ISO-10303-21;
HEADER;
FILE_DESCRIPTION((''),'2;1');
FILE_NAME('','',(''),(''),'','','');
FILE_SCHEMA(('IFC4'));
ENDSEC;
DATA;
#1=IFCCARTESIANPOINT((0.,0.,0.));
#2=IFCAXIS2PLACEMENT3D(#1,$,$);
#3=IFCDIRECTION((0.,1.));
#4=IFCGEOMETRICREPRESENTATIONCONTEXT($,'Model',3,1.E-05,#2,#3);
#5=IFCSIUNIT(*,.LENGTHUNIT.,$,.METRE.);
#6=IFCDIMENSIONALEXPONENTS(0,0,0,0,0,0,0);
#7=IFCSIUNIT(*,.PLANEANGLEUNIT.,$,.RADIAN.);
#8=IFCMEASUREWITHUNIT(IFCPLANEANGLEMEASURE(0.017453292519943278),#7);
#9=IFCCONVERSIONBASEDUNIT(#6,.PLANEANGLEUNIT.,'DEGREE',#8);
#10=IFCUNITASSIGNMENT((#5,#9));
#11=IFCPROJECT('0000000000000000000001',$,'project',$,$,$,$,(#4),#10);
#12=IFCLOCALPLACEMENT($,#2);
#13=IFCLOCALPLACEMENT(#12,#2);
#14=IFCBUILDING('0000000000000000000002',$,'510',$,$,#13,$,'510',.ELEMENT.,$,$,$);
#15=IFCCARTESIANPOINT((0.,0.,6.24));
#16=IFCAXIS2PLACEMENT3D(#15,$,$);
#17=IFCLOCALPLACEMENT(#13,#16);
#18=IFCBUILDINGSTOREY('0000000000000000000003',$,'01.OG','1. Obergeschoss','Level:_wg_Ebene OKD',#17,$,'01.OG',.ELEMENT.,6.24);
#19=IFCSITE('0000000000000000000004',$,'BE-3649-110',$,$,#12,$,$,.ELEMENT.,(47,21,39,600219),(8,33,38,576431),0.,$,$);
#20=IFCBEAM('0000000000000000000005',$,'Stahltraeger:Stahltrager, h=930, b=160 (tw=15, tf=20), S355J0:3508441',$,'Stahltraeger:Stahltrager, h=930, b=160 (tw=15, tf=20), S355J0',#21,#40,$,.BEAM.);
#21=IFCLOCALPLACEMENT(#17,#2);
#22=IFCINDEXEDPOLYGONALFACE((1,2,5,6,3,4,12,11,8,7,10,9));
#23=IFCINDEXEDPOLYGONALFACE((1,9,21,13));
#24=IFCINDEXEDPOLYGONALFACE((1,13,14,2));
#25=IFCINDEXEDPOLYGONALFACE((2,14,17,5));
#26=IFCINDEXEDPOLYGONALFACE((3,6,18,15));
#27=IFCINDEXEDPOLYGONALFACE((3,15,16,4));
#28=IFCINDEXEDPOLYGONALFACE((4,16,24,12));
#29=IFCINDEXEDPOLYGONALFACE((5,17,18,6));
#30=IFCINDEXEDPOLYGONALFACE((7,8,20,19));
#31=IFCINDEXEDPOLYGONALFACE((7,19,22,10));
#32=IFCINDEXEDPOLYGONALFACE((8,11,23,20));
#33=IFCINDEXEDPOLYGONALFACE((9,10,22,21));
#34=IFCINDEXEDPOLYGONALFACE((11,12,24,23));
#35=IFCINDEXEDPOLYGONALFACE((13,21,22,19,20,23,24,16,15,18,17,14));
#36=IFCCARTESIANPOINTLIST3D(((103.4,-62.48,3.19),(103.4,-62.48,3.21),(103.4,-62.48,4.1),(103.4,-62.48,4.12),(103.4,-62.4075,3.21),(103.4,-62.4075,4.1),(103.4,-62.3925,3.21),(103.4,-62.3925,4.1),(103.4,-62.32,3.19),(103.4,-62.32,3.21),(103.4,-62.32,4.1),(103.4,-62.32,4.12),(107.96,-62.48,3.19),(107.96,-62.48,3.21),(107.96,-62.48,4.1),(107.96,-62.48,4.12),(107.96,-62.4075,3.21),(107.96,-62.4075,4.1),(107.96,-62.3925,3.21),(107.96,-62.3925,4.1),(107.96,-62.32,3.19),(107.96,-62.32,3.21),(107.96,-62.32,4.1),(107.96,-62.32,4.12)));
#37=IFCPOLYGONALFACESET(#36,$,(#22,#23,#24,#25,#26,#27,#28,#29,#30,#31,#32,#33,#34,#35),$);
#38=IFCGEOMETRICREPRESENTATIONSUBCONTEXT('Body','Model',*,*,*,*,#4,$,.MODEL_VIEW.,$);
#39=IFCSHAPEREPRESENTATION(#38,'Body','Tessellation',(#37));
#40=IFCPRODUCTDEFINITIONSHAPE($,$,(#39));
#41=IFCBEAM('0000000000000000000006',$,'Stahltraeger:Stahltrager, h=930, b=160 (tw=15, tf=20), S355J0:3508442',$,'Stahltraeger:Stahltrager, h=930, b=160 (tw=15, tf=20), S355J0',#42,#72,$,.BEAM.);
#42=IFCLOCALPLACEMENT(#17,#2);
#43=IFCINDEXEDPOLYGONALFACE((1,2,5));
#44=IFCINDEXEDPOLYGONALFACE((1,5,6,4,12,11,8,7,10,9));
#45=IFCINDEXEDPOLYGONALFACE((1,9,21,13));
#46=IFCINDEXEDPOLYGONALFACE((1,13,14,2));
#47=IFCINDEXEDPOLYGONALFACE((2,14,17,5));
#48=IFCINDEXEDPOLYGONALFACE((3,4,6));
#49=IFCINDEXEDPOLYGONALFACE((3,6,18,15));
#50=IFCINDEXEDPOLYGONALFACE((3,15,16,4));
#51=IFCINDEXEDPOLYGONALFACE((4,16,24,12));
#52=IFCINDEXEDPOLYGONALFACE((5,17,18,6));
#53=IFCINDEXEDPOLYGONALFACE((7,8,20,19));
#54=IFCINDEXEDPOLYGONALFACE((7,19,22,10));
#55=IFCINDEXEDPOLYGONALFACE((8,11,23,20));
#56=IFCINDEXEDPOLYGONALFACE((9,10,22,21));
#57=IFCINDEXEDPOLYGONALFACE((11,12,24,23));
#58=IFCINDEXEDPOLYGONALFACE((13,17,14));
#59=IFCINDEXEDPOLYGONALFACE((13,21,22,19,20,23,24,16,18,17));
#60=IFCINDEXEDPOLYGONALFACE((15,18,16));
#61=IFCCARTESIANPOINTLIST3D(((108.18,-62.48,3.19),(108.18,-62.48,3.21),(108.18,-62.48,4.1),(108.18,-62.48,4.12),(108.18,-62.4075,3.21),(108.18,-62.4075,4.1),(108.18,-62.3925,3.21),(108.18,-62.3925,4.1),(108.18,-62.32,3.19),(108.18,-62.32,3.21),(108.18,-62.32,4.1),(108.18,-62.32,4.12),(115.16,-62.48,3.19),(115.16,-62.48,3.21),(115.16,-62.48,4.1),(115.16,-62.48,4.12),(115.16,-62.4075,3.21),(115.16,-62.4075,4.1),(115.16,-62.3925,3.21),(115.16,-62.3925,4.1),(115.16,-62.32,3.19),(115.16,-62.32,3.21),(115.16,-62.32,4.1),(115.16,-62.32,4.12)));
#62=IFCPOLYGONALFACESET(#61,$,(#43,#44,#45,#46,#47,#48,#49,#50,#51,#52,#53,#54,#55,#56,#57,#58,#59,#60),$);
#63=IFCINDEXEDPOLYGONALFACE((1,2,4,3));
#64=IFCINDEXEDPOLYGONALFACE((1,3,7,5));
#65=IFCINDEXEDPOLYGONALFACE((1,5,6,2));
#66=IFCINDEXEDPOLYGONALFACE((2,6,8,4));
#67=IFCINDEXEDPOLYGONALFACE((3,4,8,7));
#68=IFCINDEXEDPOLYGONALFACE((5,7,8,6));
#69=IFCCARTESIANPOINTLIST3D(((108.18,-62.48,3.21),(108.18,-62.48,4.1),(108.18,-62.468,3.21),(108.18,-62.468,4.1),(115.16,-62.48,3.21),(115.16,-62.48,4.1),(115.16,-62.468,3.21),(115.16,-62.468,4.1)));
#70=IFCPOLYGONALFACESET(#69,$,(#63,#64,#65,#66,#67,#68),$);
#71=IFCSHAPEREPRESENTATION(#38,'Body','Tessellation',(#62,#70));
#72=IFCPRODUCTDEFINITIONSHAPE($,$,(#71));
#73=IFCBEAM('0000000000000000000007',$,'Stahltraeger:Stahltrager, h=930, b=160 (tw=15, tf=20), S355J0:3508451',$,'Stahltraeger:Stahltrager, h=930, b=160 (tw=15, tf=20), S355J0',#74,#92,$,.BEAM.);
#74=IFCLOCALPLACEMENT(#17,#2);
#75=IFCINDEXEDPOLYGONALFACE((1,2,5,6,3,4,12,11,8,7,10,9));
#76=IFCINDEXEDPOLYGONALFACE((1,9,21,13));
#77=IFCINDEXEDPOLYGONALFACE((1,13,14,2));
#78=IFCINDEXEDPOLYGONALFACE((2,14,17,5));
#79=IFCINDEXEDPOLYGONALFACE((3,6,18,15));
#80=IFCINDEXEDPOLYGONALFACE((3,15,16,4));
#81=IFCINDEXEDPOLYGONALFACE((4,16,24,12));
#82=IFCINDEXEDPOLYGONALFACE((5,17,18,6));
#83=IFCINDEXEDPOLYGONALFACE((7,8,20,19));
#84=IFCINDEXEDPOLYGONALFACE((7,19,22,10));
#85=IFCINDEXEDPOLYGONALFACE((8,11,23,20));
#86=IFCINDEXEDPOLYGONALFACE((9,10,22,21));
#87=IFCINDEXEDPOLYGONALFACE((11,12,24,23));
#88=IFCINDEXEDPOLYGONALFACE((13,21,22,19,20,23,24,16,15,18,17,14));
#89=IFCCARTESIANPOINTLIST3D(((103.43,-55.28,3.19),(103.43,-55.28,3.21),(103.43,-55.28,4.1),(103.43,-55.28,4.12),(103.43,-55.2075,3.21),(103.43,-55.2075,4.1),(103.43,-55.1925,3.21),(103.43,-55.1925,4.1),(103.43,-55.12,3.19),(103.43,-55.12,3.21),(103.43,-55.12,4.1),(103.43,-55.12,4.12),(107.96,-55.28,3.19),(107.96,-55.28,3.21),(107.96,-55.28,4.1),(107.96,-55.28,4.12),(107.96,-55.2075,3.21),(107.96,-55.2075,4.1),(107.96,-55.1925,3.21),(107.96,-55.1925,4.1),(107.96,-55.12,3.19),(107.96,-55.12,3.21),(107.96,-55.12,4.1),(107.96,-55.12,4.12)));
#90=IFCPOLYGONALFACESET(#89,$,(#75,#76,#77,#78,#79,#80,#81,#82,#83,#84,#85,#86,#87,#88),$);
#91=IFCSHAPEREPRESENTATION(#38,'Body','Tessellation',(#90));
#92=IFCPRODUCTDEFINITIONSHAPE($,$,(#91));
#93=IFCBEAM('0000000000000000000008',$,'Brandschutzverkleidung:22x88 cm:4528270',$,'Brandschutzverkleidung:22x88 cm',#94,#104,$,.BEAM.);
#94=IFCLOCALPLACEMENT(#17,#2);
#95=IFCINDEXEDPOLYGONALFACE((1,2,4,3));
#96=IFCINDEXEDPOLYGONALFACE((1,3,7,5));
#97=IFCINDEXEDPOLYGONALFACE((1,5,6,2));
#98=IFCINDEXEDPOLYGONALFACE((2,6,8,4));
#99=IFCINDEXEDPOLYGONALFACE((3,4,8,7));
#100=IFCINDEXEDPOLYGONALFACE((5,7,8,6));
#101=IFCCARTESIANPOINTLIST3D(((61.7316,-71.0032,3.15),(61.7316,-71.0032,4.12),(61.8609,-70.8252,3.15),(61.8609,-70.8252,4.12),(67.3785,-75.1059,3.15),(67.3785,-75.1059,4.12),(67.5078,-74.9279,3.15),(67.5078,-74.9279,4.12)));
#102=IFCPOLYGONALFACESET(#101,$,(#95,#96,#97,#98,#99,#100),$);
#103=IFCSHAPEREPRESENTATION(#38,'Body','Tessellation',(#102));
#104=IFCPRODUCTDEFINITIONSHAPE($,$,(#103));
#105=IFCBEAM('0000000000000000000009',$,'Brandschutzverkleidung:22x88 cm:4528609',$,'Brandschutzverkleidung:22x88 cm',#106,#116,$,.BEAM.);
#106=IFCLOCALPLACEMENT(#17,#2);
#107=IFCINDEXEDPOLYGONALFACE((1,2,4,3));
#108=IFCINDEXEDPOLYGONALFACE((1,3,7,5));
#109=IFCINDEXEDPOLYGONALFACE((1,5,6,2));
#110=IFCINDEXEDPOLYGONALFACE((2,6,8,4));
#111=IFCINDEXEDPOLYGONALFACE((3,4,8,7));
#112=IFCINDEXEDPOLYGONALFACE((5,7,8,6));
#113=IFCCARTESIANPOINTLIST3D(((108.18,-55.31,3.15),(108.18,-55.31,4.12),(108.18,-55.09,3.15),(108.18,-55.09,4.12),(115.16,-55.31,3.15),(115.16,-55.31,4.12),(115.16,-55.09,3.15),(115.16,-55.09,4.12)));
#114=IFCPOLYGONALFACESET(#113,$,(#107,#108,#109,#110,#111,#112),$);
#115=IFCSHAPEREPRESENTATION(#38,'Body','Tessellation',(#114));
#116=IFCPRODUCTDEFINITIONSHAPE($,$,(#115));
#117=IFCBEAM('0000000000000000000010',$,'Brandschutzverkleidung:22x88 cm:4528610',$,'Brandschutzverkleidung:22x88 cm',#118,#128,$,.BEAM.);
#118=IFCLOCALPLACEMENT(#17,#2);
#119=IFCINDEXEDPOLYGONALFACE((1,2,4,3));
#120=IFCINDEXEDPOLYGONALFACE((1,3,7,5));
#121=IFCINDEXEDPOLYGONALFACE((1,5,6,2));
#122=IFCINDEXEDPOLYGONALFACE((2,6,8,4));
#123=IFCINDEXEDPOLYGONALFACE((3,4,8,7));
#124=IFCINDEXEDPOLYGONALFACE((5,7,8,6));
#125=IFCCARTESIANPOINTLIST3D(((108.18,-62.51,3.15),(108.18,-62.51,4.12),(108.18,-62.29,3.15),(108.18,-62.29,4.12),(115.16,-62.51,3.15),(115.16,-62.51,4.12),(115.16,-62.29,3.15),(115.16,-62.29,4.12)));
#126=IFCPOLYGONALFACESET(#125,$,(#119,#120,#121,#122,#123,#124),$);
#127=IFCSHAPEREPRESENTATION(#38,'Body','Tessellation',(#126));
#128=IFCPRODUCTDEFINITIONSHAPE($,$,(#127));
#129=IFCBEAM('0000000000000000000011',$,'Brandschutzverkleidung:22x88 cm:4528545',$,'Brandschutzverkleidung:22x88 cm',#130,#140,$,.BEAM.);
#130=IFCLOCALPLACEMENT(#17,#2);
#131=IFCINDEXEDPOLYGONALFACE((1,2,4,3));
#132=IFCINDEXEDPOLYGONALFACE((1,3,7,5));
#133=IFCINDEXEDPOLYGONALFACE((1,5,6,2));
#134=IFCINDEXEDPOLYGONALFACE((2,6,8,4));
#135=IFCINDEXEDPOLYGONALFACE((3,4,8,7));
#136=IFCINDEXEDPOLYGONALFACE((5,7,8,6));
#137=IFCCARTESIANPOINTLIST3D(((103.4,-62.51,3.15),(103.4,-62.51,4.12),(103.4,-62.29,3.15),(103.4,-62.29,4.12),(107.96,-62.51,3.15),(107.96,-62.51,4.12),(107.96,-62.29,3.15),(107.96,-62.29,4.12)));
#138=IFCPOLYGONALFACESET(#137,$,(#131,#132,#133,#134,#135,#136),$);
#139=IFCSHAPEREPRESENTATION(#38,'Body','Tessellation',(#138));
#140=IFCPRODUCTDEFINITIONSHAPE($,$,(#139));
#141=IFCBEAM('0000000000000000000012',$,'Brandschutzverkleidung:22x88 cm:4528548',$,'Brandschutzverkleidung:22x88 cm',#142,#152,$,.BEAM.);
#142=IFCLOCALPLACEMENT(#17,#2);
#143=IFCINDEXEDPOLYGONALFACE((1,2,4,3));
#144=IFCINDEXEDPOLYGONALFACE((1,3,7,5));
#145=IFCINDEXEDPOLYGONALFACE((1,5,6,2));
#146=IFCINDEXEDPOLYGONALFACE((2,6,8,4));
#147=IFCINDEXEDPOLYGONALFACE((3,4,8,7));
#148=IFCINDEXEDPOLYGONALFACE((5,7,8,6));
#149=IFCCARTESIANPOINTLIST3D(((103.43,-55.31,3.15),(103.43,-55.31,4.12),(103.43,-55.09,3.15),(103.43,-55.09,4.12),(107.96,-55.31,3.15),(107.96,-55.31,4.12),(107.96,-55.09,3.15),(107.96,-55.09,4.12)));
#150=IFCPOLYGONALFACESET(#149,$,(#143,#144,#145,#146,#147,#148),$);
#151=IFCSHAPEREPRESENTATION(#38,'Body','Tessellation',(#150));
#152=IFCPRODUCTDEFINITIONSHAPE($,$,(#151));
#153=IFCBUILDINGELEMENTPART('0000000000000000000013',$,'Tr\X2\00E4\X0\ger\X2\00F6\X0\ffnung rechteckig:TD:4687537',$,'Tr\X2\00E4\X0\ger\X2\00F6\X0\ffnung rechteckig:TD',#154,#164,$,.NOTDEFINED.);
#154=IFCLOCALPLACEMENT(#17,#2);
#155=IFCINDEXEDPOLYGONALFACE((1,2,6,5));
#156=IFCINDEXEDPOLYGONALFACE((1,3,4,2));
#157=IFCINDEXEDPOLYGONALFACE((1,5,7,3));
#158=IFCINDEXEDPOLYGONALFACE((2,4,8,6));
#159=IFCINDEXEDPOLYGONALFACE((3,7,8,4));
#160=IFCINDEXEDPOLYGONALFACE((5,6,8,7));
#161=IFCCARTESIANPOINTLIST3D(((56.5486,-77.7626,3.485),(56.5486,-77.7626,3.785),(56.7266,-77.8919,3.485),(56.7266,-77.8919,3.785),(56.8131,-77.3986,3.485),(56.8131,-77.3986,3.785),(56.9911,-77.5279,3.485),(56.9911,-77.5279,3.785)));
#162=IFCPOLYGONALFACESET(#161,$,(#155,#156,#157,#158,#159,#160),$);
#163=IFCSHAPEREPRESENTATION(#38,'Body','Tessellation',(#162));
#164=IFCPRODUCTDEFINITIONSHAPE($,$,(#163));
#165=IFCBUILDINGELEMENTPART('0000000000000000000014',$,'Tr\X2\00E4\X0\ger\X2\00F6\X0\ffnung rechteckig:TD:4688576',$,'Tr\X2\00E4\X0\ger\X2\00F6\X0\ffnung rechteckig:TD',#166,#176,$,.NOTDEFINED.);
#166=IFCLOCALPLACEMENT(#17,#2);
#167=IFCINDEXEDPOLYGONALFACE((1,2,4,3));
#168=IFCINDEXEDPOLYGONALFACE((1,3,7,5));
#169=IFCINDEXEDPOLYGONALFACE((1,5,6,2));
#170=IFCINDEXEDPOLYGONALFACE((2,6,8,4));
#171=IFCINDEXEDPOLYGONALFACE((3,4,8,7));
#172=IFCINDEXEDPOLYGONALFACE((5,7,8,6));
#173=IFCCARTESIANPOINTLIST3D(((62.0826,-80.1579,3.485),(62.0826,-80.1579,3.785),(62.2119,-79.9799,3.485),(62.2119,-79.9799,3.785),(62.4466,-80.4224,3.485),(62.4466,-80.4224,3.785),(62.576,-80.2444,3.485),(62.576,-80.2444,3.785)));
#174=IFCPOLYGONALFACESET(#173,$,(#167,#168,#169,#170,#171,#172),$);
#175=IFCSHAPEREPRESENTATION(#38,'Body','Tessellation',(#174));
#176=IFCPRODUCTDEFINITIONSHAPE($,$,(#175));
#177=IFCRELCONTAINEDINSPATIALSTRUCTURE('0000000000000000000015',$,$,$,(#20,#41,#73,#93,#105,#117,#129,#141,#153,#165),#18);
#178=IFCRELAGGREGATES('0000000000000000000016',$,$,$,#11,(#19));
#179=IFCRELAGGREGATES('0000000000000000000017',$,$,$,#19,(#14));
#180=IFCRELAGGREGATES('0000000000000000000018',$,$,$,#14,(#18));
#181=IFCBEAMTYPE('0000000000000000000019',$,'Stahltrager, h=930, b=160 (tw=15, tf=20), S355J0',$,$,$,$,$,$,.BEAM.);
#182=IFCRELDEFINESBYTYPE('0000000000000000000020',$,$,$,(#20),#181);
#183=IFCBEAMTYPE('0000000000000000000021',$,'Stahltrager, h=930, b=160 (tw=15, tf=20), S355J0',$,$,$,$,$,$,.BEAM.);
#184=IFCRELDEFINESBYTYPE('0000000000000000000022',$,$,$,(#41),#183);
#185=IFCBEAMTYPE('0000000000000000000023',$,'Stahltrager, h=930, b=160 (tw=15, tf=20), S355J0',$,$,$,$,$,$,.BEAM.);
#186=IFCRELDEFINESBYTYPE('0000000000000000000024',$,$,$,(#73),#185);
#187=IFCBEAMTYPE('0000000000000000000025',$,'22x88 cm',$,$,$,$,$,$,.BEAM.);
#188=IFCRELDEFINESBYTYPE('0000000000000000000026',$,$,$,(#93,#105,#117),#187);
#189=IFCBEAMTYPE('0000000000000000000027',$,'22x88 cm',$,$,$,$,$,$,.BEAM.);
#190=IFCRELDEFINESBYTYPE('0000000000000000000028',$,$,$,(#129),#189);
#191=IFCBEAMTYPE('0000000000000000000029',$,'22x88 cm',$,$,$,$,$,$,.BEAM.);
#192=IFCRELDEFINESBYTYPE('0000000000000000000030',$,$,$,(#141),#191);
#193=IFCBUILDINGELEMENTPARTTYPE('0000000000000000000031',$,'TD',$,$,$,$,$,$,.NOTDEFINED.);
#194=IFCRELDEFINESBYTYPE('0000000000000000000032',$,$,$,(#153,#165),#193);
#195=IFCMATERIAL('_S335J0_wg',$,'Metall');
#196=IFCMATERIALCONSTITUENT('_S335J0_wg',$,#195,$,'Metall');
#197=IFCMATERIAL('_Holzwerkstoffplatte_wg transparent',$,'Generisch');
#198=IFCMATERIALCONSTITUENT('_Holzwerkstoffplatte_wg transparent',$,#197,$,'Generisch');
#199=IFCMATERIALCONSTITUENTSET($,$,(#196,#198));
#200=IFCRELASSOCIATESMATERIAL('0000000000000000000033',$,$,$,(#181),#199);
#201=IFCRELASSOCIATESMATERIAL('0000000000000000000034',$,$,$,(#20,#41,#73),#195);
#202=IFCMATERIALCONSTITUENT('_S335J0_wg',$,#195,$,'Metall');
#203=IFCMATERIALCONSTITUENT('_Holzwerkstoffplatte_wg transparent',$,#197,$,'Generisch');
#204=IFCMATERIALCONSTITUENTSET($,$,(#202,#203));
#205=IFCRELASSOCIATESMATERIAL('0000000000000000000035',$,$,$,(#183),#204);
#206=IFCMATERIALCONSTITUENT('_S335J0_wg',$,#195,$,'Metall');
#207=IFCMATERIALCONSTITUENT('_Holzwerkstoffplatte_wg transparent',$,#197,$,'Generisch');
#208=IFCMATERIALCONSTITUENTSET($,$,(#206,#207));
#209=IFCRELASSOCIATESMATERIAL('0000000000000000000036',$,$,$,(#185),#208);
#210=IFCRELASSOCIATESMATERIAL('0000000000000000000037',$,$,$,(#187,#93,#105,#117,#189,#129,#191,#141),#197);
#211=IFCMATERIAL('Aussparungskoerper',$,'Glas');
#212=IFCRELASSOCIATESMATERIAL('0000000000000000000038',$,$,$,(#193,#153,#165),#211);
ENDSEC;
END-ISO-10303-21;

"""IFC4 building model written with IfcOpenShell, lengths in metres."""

from ifc_helpers import new_model, entity, si_unit, converted_unit, direction, frame, origin, place, context, subcontext, project, spatial, indexed_curve, outline, extrude, source, transform, mapped, material, constituent, constituent_set, type_object, type_shapes, element, save


model = new_model("IFC4")

# Units and contexts
model_context = context("Model", 3, precision=1e-05, world=origin(), true_north=direction((0.0, 1.0)))
body_context = subcontext(model_context, "Body", "Model", "MODEL_VIEW")
ifc_project = project(units=[si_unit("LENGTHUNIT", "METRE"), converted_unit("PLANEANGLEUNIT", "DEGREE", entity("IfcPlaneAngleMeasure", 0.017453292519943278), si_unit("PLANEANGLEUNIT", "RADIAN"), dimensions=[0, 0, 0, 0, 0, 0, 0])], contexts=[model_context])

# Site, building, storey
site_placement = place(None, origin())
site = spatial("IfcSite", under=ifc_project, at=site_placement, Name="BE-3649-110", CompositionType="ELEMENT", RefLatitude=(47, 21, 39, 600219), RefLongitude=(8, 33, 38, 576431), RefElevation=0.0)
building_placement = place(site_placement, origin())
building = spatial("IfcBuilding", under=site, at=building_placement, Name="510", LongName="510", CompositionType="ELEMENT")
storey_placement = place(building_placement, frame((0.0, 0.0, 6.24)))
storey = spatial("IfcBuildingStorey", under=building, at=storey_placement, Name="01.OG", Description="1. Obergeschoss", ObjectType="Level:_wg_Ebene OKD", LongName="01.OG", CompositionType="ELEMENT", Elevation=6.24)

# Shared definitions
ifc_material_1 = material(Name="_S335J0_wg", Category="Metall")

# Shared definitions
ifc_material_2 = material(Name="_Holzwerkstoffplatte_wg transparent", Category="Generisch")

# Beams
ifc_constituent_1 = constituent(ifc_material_1, Name="_S335J0_wg", Category="Metall")
ifc_constituent_2 = constituent(ifc_material_2, Name="_Holzwerkstoffplatte_wg transparent", Category="Generisch")
ifc_constituent_set_1 = constituent_set(constituents=[ifc_constituent_1, ifc_constituent_2])
beam_type_1 = type_object("IfcBeamType", Name="Stahltrager, h=930, b=160 (tw=15, tf=20), S355J0", PredefinedType="BEAM", material=ifc_constituent_set_1)
shared_shape_1 = source(origin(), body_context, "Body", "SweptSolid", [
    extrude(outline(indexed_curve([(-0.465, -0.08), (-0.445, -0.08), (-0.445, -0.0075), (0.445, -0.0075), (0.445, -0.08), (0.465, -0.08), (0.465, 0.08), (0.445, 0.08), (0.445, 0.0075), (-0.445, 0.0075), (-0.445, 0.08), (-0.465, 0.08), (-0.465, -0.08)], self_intersect=False)), frame((-2.28, 0.0, 0.0), z_axis=(1.0, 0.0, 0.0), x_axis=(0.0, 0.0, -1.0)), (0.0, 0.0, 1.0), 4.56),
])
type_shapes(beam_type_1, [shared_shape_1])
beam_1_placement = place(storey_placement, frame((105.68, -62.4, 3.655)))
element("IfcBeam", 1, at=beam_1_placement, inside=storey, type_object=beam_type_1, material=ifc_material_1, Name="Stahltraeger:Stahltrager, h=930, b=160 (tw=15, tf=20), S355J0:3508441", ObjectType="Stahltraeger:Stahltrager, h=930, b=160 (tw=15, tf=20), S355J0", PredefinedType="BEAM", context=body_context, shape_type="MappedRepresentation", body=[
    mapped(shared_shape_1, transform((0.0, 0.0, 0.0), scale=1.0)),
])
ifc_constituent_3 = constituent(ifc_material_1, Name="_S335J0_wg", Category="Metall")
ifc_constituent_4 = constituent(ifc_material_2, Name="_Holzwerkstoffplatte_wg transparent", Category="Generisch")
ifc_constituent_set_2 = constituent_set(constituents=[ifc_constituent_3, ifc_constituent_4])
beam_type_2 = type_object("IfcBeamType", Name="Stahltrager, h=930, b=160 (tw=15, tf=20), S355J0", PredefinedType="BEAM", material=ifc_constituent_set_2)
shared_shape_2 = source(origin(), body_context, "Body", "SweptSolid", [
    extrude(outline(indexed_curve([(-0.465, -0.08), (-0.445, -0.08), (-0.445, -0.0075), (0.445, -0.0075), (0.445, -0.08), (0.465, -0.08), (0.465, 0.08), (0.445, 0.08), (0.445, 0.0075), (-0.445, 0.0075), (-0.445, 0.08), (-0.465, 0.08), (-0.465, -0.08)], self_intersect=False)), frame((-3.49, 0.0, 0.0), z_axis=(1.0, 0.0, 0.0), x_axis=(0.0, 0.0, -1.0)), (0.0, 0.0, 1.0), 6.98),
    extrude(outline(indexed_curve([(-0.445, -0.006), (0.445, -0.006), (0.445, 0.006), (-0.445, 0.006), (-0.445, -0.006)], self_intersect=False)), frame((-3.49, -0.074, 0.0), z_axis=(1.0, 0.0, 0.0), x_axis=(0.0, 0.0, -1.0)), (0.0, 0.0, 1.0), 6.98),
])
type_shapes(beam_type_2, [shared_shape_2])
beam_2_placement = place(storey_placement, frame((111.67, -62.4, 3.655)))
element("IfcBeam", 2, at=beam_2_placement, inside=storey, type_object=beam_type_2, material=ifc_material_1, Name="Stahltraeger:Stahltrager, h=930, b=160 (tw=15, tf=20), S355J0:3508442", ObjectType="Stahltraeger:Stahltrager, h=930, b=160 (tw=15, tf=20), S355J0", PredefinedType="BEAM", context=body_context, shape_type="MappedRepresentation", body=[
    mapped(shared_shape_2, transform((0.0, 0.0, 0.0), scale=1.0)),
])
ifc_constituent_5 = constituent(ifc_material_1, Name="_S335J0_wg", Category="Metall")
ifc_constituent_6 = constituent(ifc_material_2, Name="_Holzwerkstoffplatte_wg transparent", Category="Generisch")
ifc_constituent_set_3 = constituent_set(constituents=[ifc_constituent_5, ifc_constituent_6])
beam_type_3 = type_object("IfcBeamType", Name="Stahltrager, h=930, b=160 (tw=15, tf=20), S355J0", PredefinedType="BEAM", material=ifc_constituent_set_3)
shared_shape_3 = source(origin(), body_context, "Body", "SweptSolid", [
    extrude(outline(indexed_curve([(-0.465, -0.08), (-0.445, -0.08), (-0.445, -0.0075), (0.445, -0.0075), (0.445, -0.08), (0.465, -0.08), (0.465, 0.08), (0.445, 0.08), (0.445, 0.0075), (-0.445, 0.0075), (-0.445, 0.08), (-0.465, 0.08), (-0.465, -0.08)], self_intersect=False)), frame((-2.265, 0.0, 0.0), z_axis=(1.0, 0.0, 0.0), x_axis=(0.0, 0.0, -1.0)), (0.0, 0.0, 1.0), 4.53),
])
type_shapes(beam_type_3, [shared_shape_3])
beam_3_placement = place(storey_placement, frame((105.695, -55.2, 3.655)))
element("IfcBeam", 3, at=beam_3_placement, inside=storey, type_object=beam_type_3, material=ifc_material_1, Name="Stahltraeger:Stahltrager, h=930, b=160 (tw=15, tf=20), S355J0:3508451", ObjectType="Stahltraeger:Stahltrager, h=930, b=160 (tw=15, tf=20), S355J0", PredefinedType="BEAM", context=body_context, shape_type="MappedRepresentation", body=[
    mapped(shared_shape_3, transform((0.0, 0.0, 0.0), scale=1.0)),
])
beam_type_4 = type_object("IfcBeamType", Name="22x88 cm", PredefinedType="BEAM", material=ifc_material_2)
shared_shape_4 = source(origin(), body_context, "Body", "SweptSolid", [
    extrude(outline(indexed_curve([(-3.49, -0.11), (3.49, -0.11), (3.49, 0.11), (-3.49, 0.11), (-3.49, -0.11)], self_intersect=False)), frame((0.0, 0.0, -0.485)), (0.0, 0.0, 1.0), 0.97),
])
type_shapes(beam_type_4, [shared_shape_4])
beam_4_placement = place(storey_placement, frame((64.6197, -72.9655, 3.635), z_axis=(0.0, 0.0, 1.0), x_axis=(0.809017, -0.587785, 0.0)))
element("IfcBeam", 4, at=beam_4_placement, inside=storey, type_object=beam_type_4, material=ifc_material_2, Name="Brandschutzverkleidung:22x88 cm:4528270", ObjectType="Brandschutzverkleidung:22x88 cm", PredefinedType="BEAM", context=body_context, shape_type="MappedRepresentation", body=[
    mapped(shared_shape_4, transform((0.0, 0.0, 0.0), scale=1.0)),
])
for number, where, name in (
    (5, (111.67, -55.2, 3.635), "Brandschutzverkleidung:22x88 cm:4528609"),
    (6, (111.67, -62.4, 3.635), "Brandschutzverkleidung:22x88 cm:4528610"),
):
    element("IfcBeam", number, at=place(storey_placement, frame(where)), inside=storey, type_object=beam_type_4, material=ifc_material_2, Name=name, ObjectType="Brandschutzverkleidung:22x88 cm", PredefinedType="BEAM", context=body_context, shape_type="MappedRepresentation", body=[
        mapped(shared_shape_4, transform((0.0, 0.0, 0.0), scale=1.0)),
    ])
beam_type_5 = type_object("IfcBeamType", Name="22x88 cm", PredefinedType="BEAM", material=ifc_material_2)
shared_shape_5 = source(origin(), body_context, "Body", "SweptSolid", [
    extrude(outline(indexed_curve([(-2.28, -0.11), (2.28, -0.11), (2.28, 0.11), (-2.28, 0.11), (-2.28, -0.11)], self_intersect=False)), frame((0.0, 0.0, -0.485)), (0.0, 0.0, 1.0), 0.97),
])
type_shapes(beam_type_5, [shared_shape_5])
beam_5_placement = place(storey_placement, frame((105.68, -62.4, 3.635)))
element("IfcBeam", 7, at=beam_5_placement, inside=storey, type_object=beam_type_5, material=ifc_material_2, Name="Brandschutzverkleidung:22x88 cm:4528545", ObjectType="Brandschutzverkleidung:22x88 cm", PredefinedType="BEAM", context=body_context, shape_type="MappedRepresentation", body=[
    mapped(shared_shape_5, transform((0.0, 0.0, 0.0), scale=1.0)),
])
beam_type_6 = type_object("IfcBeamType", Name="22x88 cm", PredefinedType="BEAM", material=ifc_material_2)
shared_shape_6 = source(origin(), body_context, "Body", "SweptSolid", [
    extrude(outline(indexed_curve([(-2.265, -0.11), (2.265, -0.11), (2.265, 0.11), (-2.265, 0.11), (-2.265, -0.11)], self_intersect=False)), frame((0.0, 0.0, -0.485)), (0.0, 0.0, 1.0), 0.97),
])
type_shapes(beam_type_6, [shared_shape_6])
beam_6_placement = place(storey_placement, frame((105.695, -55.2, 3.635)))
element("IfcBeam", 8, at=beam_6_placement, inside=storey, type_object=beam_type_6, material=ifc_material_2, Name="Brandschutzverkleidung:22x88 cm:4528548", ObjectType="Brandschutzverkleidung:22x88 cm", PredefinedType="BEAM", context=body_context, shape_type="MappedRepresentation", body=[
    mapped(shared_shape_6, transform((0.0, 0.0, 0.0), scale=1.0)),
])

# Building element parts
ifc_material_3 = material(Name="Aussparungskoerper", Category="Glas")
building_element_part_type_1 = type_object("IfcBuildingElementPartType", Name="TD", PredefinedType="NOTDEFINED", material=ifc_material_3)
shared_shape_7 = source(origin(), body_context, "Body", "SweptSolid", [
    extrude(outline(indexed_curve([(-0.225, -0.15), (0.225, -0.15), (0.225, 0.15), (-0.225, 0.15), (-0.225, -0.15)], self_intersect=False)), frame((0.0, 0.0, -0.22), z_axis=(0.0, 0.0, 1.0), x_axis=(-1.0, 0.0, 0.0)), (0.0, 0.0, 1.0), 0.22),
])
type_shapes(building_element_part_type_1, [shared_shape_7])
for number, where, z_axis, x_axis, name in (
    (9, (56.8588, -77.7099, 3.635), (0.809017, -0.587785, 0.0), (-0.587785, -0.809017, 0.0), "Trägeröffnung rechteckig:TD:4687537"),
    (10, (62.2646, -80.2901, 3.635), (-0.587785, -0.809017, 0.0), (0.809017, -0.587785, 0.0), "Trägeröffnung rechteckig:TD:4688576"),
):
    element("IfcBuildingElementPart", number, at=place(storey_placement, frame(where, z_axis=z_axis, x_axis=x_axis)), inside=storey, type_object=building_element_part_type_1, material=ifc_material_3, Name=name, ObjectType="Trägeröffnung rechteckig:TD", PredefinedType="NOTDEFINED", context=body_context, shape_type="MappedRepresentation", body=[
        mapped(shared_shape_7, transform((0.0, 0.0, 0.0), scale=1.0)),
    ])

save(model, "model.ifc")
